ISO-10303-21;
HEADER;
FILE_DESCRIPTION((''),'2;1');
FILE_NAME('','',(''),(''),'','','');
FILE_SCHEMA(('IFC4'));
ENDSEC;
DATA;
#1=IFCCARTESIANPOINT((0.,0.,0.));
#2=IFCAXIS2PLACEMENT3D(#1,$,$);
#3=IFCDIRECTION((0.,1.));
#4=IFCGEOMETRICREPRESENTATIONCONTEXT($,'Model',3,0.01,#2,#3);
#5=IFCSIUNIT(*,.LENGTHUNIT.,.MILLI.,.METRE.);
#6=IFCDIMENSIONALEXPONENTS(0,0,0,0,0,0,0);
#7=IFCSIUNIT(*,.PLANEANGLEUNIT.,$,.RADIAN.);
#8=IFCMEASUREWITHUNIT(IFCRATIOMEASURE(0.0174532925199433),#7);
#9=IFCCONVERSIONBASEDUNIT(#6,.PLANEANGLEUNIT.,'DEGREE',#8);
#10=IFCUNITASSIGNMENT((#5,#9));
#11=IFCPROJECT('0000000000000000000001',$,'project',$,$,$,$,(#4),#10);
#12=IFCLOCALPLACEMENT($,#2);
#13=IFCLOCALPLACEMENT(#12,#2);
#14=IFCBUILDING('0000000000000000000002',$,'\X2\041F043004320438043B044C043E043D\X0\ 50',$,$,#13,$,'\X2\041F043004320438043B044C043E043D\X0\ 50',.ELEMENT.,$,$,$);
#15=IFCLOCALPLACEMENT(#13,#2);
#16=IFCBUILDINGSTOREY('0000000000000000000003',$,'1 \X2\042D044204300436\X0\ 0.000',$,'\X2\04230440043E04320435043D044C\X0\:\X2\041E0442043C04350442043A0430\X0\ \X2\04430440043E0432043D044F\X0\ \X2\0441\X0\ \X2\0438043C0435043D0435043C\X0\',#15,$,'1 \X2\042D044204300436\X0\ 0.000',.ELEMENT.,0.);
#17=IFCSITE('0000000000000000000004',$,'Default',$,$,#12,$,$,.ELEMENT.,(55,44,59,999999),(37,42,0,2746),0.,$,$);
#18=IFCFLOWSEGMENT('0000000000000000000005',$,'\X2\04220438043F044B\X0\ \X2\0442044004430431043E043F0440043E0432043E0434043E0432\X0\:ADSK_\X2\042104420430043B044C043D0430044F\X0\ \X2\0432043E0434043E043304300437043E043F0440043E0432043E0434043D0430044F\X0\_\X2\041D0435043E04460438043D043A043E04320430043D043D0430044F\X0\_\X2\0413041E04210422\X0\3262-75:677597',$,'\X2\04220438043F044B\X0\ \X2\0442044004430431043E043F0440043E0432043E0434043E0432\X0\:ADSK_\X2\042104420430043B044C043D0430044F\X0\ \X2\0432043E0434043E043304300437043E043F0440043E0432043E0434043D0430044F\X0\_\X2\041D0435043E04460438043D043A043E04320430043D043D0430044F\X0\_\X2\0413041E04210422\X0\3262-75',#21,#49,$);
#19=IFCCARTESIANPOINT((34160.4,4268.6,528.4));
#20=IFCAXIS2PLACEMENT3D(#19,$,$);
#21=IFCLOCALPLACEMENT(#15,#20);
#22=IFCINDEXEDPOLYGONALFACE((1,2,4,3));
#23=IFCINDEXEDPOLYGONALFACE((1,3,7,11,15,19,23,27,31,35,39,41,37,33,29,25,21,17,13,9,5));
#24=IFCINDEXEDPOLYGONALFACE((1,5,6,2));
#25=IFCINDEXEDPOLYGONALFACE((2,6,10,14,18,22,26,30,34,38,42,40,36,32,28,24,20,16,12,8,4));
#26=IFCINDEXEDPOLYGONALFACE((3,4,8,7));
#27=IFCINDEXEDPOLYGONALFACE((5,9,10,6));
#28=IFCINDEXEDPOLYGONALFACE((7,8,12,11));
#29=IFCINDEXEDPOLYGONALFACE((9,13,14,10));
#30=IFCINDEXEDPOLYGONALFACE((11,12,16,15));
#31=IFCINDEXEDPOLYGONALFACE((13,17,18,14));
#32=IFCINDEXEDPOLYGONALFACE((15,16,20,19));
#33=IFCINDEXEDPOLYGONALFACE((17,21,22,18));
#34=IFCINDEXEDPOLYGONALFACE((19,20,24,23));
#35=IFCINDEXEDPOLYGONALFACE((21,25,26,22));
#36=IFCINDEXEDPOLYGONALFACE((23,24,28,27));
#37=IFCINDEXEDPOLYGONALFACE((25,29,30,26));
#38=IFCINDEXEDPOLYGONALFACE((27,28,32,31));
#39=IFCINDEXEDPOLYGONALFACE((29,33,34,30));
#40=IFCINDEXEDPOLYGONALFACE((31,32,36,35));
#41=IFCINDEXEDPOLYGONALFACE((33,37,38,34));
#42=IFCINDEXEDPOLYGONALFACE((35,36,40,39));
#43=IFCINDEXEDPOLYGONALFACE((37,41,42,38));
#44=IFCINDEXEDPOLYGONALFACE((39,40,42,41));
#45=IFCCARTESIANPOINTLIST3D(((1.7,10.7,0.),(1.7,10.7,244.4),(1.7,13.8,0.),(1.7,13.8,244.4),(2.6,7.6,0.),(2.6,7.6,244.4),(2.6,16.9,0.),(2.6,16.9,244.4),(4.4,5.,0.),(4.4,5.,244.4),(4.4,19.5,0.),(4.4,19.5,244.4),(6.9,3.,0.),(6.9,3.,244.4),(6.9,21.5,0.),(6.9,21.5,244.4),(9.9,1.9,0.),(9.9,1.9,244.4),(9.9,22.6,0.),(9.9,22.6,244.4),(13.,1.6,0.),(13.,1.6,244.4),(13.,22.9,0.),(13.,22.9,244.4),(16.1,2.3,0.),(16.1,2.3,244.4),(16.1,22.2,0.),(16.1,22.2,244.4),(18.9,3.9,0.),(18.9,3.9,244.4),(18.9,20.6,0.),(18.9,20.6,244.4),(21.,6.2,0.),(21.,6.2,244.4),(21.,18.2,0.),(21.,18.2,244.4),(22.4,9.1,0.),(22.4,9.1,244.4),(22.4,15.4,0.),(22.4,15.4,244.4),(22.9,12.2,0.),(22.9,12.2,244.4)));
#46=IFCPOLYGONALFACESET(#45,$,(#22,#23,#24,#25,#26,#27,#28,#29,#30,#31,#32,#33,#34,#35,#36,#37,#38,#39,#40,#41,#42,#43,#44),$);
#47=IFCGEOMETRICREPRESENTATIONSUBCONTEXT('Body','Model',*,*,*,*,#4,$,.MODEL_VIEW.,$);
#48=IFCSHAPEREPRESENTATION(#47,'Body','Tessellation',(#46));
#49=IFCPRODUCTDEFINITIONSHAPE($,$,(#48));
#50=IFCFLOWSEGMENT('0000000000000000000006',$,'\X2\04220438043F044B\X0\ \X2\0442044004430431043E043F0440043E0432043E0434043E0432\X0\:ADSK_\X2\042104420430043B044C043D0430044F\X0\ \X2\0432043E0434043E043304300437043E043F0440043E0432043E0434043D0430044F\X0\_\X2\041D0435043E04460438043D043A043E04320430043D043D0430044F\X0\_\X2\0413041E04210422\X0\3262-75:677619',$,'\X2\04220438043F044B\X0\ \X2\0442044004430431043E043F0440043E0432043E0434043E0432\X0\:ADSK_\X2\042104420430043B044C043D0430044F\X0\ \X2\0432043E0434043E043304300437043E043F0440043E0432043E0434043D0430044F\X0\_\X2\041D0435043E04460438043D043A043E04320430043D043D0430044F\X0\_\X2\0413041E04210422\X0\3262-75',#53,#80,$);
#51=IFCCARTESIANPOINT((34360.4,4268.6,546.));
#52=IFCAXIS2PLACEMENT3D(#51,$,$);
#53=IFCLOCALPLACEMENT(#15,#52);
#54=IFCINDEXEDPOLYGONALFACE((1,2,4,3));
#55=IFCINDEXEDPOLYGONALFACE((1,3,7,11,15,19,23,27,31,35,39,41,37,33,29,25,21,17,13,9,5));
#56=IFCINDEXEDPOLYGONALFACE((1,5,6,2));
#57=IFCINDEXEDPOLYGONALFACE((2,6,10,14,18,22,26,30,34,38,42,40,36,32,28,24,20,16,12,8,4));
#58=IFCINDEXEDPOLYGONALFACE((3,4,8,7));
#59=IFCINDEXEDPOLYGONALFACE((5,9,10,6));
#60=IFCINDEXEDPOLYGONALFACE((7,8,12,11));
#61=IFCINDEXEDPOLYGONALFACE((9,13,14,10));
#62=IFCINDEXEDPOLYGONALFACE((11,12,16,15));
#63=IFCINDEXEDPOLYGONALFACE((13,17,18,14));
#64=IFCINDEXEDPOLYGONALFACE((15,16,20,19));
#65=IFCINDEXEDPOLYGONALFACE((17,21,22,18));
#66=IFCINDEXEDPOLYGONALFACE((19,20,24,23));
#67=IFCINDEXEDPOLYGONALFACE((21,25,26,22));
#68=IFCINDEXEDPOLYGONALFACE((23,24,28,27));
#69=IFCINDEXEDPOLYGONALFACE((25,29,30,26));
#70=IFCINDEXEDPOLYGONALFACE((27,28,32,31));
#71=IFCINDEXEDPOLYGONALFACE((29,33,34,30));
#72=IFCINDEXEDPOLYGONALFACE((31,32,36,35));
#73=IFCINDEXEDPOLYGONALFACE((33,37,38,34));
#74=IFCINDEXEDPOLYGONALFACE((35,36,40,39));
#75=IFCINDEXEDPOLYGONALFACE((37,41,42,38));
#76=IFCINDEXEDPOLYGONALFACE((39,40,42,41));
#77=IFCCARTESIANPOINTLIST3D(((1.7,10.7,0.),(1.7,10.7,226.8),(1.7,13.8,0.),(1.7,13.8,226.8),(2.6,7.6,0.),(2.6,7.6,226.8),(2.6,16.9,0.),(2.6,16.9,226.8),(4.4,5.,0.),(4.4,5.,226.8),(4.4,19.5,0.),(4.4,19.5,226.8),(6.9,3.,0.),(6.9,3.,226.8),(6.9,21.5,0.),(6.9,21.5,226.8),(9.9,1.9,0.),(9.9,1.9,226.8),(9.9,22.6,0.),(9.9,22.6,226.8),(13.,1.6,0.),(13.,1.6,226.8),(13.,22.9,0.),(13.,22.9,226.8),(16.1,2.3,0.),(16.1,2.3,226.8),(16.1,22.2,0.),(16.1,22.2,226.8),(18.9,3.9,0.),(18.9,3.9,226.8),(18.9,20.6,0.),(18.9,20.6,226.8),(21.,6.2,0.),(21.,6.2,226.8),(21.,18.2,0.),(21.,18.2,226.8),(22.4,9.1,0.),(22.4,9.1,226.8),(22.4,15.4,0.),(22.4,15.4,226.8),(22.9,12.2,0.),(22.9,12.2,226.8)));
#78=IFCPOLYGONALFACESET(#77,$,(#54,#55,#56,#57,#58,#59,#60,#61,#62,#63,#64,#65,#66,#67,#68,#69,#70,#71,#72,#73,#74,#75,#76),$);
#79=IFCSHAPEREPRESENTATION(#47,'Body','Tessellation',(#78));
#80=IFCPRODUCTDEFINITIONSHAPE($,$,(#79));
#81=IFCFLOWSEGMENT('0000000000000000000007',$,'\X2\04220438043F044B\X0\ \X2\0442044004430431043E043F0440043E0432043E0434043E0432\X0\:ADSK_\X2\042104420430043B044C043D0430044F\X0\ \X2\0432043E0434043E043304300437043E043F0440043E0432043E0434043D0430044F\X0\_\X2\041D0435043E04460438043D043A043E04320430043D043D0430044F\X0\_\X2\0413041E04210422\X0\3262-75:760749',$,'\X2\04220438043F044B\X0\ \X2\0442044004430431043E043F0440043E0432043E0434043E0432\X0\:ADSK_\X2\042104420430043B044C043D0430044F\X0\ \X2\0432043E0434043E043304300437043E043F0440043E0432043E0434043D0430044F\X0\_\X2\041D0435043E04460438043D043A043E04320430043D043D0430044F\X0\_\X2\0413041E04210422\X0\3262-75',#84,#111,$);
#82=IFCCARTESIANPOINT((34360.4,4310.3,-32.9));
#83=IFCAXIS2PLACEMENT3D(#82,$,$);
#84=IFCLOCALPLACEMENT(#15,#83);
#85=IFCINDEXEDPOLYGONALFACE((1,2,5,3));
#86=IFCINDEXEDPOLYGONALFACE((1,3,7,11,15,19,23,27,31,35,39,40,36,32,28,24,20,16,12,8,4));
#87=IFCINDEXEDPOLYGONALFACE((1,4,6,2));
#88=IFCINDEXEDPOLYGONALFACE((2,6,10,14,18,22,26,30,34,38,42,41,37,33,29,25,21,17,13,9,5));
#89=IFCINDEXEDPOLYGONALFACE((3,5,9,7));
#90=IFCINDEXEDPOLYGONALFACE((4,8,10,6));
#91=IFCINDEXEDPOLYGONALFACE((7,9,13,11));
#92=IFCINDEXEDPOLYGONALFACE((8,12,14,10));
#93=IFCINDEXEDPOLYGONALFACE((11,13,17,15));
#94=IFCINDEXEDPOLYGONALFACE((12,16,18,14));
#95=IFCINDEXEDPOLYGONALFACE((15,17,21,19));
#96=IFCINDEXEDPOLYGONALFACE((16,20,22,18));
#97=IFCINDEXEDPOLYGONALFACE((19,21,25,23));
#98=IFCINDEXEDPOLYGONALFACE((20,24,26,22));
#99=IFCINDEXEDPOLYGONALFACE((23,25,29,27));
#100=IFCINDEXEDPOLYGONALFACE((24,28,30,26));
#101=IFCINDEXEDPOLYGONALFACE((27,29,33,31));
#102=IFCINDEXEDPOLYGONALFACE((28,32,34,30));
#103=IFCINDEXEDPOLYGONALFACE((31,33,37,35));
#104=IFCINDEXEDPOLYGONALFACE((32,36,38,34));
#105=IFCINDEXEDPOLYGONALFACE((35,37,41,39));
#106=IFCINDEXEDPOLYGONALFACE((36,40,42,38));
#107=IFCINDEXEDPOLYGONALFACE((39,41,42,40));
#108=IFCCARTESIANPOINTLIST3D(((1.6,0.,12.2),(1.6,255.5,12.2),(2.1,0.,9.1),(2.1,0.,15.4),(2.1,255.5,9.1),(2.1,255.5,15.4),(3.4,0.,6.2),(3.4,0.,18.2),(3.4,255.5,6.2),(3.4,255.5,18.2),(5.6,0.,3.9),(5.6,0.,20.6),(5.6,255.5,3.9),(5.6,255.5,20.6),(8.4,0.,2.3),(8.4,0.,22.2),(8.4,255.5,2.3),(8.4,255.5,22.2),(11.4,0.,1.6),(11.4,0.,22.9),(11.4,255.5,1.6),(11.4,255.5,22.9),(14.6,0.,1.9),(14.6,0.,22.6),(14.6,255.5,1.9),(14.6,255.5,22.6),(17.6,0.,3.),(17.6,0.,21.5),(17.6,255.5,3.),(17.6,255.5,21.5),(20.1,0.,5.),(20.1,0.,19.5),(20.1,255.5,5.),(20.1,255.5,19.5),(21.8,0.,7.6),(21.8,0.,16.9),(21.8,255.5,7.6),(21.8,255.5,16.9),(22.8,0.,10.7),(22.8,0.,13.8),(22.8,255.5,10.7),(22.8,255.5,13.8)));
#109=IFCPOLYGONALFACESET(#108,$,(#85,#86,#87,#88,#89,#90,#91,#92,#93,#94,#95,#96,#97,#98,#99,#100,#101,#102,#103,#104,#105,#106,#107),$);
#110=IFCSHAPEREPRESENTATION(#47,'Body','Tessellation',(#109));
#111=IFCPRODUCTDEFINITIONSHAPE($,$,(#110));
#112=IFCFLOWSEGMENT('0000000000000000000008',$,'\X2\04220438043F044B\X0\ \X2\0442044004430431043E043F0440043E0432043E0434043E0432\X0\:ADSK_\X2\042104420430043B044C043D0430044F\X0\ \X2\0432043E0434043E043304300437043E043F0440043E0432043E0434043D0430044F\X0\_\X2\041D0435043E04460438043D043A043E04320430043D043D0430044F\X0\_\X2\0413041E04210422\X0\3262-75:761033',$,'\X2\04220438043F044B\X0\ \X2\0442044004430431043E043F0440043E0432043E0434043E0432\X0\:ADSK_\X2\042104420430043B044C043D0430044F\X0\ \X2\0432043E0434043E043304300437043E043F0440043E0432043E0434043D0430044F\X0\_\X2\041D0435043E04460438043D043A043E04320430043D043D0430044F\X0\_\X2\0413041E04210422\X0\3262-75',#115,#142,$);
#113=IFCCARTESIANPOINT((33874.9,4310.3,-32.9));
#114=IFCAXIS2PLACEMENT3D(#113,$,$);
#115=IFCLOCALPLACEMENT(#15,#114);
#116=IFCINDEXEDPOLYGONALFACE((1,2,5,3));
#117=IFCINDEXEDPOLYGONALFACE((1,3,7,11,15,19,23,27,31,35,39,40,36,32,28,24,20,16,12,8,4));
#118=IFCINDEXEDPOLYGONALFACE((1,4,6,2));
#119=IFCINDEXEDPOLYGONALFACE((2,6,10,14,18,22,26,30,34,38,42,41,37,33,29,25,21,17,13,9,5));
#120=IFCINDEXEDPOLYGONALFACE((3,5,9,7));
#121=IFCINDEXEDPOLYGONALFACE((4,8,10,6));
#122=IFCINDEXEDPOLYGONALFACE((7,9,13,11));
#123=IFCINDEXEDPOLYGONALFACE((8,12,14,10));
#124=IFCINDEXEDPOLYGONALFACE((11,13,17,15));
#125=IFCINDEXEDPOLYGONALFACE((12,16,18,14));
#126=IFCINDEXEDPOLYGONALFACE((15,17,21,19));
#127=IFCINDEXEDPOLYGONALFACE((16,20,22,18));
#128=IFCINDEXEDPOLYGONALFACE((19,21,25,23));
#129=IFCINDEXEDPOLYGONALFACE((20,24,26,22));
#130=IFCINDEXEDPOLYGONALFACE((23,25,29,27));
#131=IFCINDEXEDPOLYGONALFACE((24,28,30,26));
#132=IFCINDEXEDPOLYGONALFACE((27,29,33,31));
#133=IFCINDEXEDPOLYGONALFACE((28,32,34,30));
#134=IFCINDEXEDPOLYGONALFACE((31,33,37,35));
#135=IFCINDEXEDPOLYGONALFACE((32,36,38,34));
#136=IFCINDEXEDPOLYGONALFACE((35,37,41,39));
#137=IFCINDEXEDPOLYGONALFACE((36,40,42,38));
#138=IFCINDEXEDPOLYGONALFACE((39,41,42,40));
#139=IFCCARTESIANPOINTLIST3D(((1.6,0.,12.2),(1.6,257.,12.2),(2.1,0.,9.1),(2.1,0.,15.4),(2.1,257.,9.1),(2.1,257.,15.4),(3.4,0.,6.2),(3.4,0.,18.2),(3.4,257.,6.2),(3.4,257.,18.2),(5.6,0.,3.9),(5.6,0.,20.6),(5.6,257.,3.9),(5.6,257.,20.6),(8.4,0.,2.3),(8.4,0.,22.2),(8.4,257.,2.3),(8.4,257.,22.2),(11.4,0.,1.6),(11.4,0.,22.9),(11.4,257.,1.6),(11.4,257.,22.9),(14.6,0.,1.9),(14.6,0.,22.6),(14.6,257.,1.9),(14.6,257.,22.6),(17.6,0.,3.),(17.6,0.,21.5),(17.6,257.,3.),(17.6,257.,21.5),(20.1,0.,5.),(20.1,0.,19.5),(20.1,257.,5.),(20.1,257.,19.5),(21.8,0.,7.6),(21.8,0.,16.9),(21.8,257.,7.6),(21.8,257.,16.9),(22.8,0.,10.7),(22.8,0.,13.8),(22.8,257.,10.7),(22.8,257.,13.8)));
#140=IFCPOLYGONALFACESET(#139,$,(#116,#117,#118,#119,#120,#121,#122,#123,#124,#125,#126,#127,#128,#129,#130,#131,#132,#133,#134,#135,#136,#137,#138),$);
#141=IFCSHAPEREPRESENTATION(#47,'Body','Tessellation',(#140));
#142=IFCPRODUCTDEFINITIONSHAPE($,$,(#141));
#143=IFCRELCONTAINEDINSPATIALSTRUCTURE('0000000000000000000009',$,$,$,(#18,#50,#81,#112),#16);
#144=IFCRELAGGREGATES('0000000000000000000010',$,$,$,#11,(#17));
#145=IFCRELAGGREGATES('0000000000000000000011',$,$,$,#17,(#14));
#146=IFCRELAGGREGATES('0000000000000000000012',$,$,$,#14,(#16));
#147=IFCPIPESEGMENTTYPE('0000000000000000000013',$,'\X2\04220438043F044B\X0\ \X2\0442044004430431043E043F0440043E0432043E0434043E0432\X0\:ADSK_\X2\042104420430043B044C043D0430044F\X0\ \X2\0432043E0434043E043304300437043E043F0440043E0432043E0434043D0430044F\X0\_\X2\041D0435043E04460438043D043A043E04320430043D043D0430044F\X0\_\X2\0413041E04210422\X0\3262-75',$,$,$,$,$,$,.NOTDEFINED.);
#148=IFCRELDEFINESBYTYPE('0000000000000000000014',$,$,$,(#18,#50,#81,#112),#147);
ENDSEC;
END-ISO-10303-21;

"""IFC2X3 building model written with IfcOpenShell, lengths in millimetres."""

from ifc_helpers import new_model, entity, si_unit, converted_unit, direction, frame, frame_2d, origin, origin_2d_with_axis, place, context, subcontext, project, spatial, circle, extrude, type_object, element, save


model = new_model("IFC2X3")

# Units and contexts
model_context = context("Model", 3, precision=0.01, world=origin(), true_north=direction((0.0, 1.0)))
body_context = subcontext(model_context, "Body", "Model", "MODEL_VIEW")
ifc_project = project(units=[si_unit("LENGTHUNIT", "METRE", prefix="MILLI"), converted_unit("PLANEANGLEUNIT", "DEGREE", entity("IfcRatioMeasure", 0.0174532925199433), si_unit("PLANEANGLEUNIT", "RADIAN"), dimensions=[0, 0, 0, 0, 0, 0, 0])], contexts=[model_context])

# Site, building, storey
site_placement = place(None, origin())
site = spatial("IfcSite", under=ifc_project, at=site_placement, Name="Default", CompositionType="ELEMENT", RefLatitude=(55, 44, 59, 999999), RefLongitude=(37, 42, 0, 2746), RefElevation=0.0)
building_placement = place(site_placement, origin())
building = spatial("IfcBuilding", under=site, at=building_placement, Name="Павильон 50", LongName="Павильон 50", CompositionType="ELEMENT")
storey_placement = place(building_placement, origin())
storey = spatial("IfcBuildingStorey", under=building, at=storey_placement, Name="1 Этаж 0.000", ObjectType="Уровень:Отметка уровня с именем", LongName="1 Этаж 0.000", CompositionType="ELEMENT", Elevation=0.0)

# Flow segments
pipe_segment_type = type_object("IfcPipeSegmentType", Name="Типы трубопроводов:ADSK_Стальная водогазопроводная_Неоцинкованная_ГОСТ3262-75", PredefinedType="NOTDEFINED")
flow_segment_1_placement = place(storey_placement, frame((34160.4, 4268.6, 528.4)))
element("IfcFlowSegment", 1, at=flow_segment_1_placement, inside=storey, type_object=pipe_segment_type, Name="Типы трубопроводов:ADSK_Стальная водогазопроводная_Неоцинкованная_ГОСТ3262-75:677597", ObjectType="Типы трубопроводов:ADSK_Стальная водогазопроводная_Неоцинкованная_ГОСТ3262-75", context=body_context, shape_type="SweptSolid", body=[
    extrude(circle(Radius=10.7, at=origin_2d_with_axis()), frame((12.2, 12.2, 0.0)), (0.0, 0.0, 1.0), 244.4),
])
flow_segment_2_placement = place(storey_placement, frame((34360.4, 4268.6, 546.0)))
element("IfcFlowSegment", 2, at=flow_segment_2_placement, inside=storey, type_object=pipe_segment_type, Name="Типы трубопроводов:ADSK_Стальная водогазопроводная_Неоцинкованная_ГОСТ3262-75:677619", ObjectType="Типы трубопроводов:ADSK_Стальная водогазопроводная_Неоцинкованная_ГОСТ3262-75", context=body_context, shape_type="SweptSolid", body=[
    extrude(circle(Radius=10.7, at=origin_2d_with_axis()), frame((12.2, 12.2, 0.0)), (0.0, 0.0, 1.0), 226.8),
])
flow_segment_3_placement = place(storey_placement, frame((34360.4, 4310.3, -32.9)))
element("IfcFlowSegment", 3, at=flow_segment_3_placement, inside=storey, type_object=pipe_segment_type, Name="Типы трубопроводов:ADSK_Стальная водогазопроводная_Неоцинкованная_ГОСТ3262-75:760749", ObjectType="Типы трубопроводов:ADSK_Стальная водогазопроводная_Неоцинкованная_ГОСТ3262-75", context=body_context, shape_type="SweptSolid", body=[
    extrude(circle(Radius=10.7, at=frame_2d((0.0, 0.0), x_axis=(1.0, 0.0))), frame((12.2, 0.0, 12.2), z_axis=(0.0, 1.0, 0.0), x_axis=(-1.0, 0.0, 0.0)), (0.0, 0.0, 1.0), 255.5),
])
flow_segment_4_placement = place(storey_placement, frame((33874.9, 4310.3, -32.9)))
element("IfcFlowSegment", 4, at=flow_segment_4_placement, inside=storey, type_object=pipe_segment_type, Name="Типы трубопроводов:ADSK_Стальная водогазопроводная_Неоцинкованная_ГОСТ3262-75:761033", ObjectType="Типы трубопроводов:ADSK_Стальная водогазопроводная_Неоцинкованная_ГОСТ3262-75", context=body_context, shape_type="SweptSolid", body=[
    extrude(circle(Radius=10.7, at=frame_2d((0.0, 0.0), x_axis=(1.0, 0.0))), frame((12.2, 0.0, 12.2), z_axis=(0.0, 1.0, 0.0), x_axis=(-1.0, 0.0, 0.0)), (0.0, 0.0, 1.0), 257.0),
])

save(model, "model.ifc")
